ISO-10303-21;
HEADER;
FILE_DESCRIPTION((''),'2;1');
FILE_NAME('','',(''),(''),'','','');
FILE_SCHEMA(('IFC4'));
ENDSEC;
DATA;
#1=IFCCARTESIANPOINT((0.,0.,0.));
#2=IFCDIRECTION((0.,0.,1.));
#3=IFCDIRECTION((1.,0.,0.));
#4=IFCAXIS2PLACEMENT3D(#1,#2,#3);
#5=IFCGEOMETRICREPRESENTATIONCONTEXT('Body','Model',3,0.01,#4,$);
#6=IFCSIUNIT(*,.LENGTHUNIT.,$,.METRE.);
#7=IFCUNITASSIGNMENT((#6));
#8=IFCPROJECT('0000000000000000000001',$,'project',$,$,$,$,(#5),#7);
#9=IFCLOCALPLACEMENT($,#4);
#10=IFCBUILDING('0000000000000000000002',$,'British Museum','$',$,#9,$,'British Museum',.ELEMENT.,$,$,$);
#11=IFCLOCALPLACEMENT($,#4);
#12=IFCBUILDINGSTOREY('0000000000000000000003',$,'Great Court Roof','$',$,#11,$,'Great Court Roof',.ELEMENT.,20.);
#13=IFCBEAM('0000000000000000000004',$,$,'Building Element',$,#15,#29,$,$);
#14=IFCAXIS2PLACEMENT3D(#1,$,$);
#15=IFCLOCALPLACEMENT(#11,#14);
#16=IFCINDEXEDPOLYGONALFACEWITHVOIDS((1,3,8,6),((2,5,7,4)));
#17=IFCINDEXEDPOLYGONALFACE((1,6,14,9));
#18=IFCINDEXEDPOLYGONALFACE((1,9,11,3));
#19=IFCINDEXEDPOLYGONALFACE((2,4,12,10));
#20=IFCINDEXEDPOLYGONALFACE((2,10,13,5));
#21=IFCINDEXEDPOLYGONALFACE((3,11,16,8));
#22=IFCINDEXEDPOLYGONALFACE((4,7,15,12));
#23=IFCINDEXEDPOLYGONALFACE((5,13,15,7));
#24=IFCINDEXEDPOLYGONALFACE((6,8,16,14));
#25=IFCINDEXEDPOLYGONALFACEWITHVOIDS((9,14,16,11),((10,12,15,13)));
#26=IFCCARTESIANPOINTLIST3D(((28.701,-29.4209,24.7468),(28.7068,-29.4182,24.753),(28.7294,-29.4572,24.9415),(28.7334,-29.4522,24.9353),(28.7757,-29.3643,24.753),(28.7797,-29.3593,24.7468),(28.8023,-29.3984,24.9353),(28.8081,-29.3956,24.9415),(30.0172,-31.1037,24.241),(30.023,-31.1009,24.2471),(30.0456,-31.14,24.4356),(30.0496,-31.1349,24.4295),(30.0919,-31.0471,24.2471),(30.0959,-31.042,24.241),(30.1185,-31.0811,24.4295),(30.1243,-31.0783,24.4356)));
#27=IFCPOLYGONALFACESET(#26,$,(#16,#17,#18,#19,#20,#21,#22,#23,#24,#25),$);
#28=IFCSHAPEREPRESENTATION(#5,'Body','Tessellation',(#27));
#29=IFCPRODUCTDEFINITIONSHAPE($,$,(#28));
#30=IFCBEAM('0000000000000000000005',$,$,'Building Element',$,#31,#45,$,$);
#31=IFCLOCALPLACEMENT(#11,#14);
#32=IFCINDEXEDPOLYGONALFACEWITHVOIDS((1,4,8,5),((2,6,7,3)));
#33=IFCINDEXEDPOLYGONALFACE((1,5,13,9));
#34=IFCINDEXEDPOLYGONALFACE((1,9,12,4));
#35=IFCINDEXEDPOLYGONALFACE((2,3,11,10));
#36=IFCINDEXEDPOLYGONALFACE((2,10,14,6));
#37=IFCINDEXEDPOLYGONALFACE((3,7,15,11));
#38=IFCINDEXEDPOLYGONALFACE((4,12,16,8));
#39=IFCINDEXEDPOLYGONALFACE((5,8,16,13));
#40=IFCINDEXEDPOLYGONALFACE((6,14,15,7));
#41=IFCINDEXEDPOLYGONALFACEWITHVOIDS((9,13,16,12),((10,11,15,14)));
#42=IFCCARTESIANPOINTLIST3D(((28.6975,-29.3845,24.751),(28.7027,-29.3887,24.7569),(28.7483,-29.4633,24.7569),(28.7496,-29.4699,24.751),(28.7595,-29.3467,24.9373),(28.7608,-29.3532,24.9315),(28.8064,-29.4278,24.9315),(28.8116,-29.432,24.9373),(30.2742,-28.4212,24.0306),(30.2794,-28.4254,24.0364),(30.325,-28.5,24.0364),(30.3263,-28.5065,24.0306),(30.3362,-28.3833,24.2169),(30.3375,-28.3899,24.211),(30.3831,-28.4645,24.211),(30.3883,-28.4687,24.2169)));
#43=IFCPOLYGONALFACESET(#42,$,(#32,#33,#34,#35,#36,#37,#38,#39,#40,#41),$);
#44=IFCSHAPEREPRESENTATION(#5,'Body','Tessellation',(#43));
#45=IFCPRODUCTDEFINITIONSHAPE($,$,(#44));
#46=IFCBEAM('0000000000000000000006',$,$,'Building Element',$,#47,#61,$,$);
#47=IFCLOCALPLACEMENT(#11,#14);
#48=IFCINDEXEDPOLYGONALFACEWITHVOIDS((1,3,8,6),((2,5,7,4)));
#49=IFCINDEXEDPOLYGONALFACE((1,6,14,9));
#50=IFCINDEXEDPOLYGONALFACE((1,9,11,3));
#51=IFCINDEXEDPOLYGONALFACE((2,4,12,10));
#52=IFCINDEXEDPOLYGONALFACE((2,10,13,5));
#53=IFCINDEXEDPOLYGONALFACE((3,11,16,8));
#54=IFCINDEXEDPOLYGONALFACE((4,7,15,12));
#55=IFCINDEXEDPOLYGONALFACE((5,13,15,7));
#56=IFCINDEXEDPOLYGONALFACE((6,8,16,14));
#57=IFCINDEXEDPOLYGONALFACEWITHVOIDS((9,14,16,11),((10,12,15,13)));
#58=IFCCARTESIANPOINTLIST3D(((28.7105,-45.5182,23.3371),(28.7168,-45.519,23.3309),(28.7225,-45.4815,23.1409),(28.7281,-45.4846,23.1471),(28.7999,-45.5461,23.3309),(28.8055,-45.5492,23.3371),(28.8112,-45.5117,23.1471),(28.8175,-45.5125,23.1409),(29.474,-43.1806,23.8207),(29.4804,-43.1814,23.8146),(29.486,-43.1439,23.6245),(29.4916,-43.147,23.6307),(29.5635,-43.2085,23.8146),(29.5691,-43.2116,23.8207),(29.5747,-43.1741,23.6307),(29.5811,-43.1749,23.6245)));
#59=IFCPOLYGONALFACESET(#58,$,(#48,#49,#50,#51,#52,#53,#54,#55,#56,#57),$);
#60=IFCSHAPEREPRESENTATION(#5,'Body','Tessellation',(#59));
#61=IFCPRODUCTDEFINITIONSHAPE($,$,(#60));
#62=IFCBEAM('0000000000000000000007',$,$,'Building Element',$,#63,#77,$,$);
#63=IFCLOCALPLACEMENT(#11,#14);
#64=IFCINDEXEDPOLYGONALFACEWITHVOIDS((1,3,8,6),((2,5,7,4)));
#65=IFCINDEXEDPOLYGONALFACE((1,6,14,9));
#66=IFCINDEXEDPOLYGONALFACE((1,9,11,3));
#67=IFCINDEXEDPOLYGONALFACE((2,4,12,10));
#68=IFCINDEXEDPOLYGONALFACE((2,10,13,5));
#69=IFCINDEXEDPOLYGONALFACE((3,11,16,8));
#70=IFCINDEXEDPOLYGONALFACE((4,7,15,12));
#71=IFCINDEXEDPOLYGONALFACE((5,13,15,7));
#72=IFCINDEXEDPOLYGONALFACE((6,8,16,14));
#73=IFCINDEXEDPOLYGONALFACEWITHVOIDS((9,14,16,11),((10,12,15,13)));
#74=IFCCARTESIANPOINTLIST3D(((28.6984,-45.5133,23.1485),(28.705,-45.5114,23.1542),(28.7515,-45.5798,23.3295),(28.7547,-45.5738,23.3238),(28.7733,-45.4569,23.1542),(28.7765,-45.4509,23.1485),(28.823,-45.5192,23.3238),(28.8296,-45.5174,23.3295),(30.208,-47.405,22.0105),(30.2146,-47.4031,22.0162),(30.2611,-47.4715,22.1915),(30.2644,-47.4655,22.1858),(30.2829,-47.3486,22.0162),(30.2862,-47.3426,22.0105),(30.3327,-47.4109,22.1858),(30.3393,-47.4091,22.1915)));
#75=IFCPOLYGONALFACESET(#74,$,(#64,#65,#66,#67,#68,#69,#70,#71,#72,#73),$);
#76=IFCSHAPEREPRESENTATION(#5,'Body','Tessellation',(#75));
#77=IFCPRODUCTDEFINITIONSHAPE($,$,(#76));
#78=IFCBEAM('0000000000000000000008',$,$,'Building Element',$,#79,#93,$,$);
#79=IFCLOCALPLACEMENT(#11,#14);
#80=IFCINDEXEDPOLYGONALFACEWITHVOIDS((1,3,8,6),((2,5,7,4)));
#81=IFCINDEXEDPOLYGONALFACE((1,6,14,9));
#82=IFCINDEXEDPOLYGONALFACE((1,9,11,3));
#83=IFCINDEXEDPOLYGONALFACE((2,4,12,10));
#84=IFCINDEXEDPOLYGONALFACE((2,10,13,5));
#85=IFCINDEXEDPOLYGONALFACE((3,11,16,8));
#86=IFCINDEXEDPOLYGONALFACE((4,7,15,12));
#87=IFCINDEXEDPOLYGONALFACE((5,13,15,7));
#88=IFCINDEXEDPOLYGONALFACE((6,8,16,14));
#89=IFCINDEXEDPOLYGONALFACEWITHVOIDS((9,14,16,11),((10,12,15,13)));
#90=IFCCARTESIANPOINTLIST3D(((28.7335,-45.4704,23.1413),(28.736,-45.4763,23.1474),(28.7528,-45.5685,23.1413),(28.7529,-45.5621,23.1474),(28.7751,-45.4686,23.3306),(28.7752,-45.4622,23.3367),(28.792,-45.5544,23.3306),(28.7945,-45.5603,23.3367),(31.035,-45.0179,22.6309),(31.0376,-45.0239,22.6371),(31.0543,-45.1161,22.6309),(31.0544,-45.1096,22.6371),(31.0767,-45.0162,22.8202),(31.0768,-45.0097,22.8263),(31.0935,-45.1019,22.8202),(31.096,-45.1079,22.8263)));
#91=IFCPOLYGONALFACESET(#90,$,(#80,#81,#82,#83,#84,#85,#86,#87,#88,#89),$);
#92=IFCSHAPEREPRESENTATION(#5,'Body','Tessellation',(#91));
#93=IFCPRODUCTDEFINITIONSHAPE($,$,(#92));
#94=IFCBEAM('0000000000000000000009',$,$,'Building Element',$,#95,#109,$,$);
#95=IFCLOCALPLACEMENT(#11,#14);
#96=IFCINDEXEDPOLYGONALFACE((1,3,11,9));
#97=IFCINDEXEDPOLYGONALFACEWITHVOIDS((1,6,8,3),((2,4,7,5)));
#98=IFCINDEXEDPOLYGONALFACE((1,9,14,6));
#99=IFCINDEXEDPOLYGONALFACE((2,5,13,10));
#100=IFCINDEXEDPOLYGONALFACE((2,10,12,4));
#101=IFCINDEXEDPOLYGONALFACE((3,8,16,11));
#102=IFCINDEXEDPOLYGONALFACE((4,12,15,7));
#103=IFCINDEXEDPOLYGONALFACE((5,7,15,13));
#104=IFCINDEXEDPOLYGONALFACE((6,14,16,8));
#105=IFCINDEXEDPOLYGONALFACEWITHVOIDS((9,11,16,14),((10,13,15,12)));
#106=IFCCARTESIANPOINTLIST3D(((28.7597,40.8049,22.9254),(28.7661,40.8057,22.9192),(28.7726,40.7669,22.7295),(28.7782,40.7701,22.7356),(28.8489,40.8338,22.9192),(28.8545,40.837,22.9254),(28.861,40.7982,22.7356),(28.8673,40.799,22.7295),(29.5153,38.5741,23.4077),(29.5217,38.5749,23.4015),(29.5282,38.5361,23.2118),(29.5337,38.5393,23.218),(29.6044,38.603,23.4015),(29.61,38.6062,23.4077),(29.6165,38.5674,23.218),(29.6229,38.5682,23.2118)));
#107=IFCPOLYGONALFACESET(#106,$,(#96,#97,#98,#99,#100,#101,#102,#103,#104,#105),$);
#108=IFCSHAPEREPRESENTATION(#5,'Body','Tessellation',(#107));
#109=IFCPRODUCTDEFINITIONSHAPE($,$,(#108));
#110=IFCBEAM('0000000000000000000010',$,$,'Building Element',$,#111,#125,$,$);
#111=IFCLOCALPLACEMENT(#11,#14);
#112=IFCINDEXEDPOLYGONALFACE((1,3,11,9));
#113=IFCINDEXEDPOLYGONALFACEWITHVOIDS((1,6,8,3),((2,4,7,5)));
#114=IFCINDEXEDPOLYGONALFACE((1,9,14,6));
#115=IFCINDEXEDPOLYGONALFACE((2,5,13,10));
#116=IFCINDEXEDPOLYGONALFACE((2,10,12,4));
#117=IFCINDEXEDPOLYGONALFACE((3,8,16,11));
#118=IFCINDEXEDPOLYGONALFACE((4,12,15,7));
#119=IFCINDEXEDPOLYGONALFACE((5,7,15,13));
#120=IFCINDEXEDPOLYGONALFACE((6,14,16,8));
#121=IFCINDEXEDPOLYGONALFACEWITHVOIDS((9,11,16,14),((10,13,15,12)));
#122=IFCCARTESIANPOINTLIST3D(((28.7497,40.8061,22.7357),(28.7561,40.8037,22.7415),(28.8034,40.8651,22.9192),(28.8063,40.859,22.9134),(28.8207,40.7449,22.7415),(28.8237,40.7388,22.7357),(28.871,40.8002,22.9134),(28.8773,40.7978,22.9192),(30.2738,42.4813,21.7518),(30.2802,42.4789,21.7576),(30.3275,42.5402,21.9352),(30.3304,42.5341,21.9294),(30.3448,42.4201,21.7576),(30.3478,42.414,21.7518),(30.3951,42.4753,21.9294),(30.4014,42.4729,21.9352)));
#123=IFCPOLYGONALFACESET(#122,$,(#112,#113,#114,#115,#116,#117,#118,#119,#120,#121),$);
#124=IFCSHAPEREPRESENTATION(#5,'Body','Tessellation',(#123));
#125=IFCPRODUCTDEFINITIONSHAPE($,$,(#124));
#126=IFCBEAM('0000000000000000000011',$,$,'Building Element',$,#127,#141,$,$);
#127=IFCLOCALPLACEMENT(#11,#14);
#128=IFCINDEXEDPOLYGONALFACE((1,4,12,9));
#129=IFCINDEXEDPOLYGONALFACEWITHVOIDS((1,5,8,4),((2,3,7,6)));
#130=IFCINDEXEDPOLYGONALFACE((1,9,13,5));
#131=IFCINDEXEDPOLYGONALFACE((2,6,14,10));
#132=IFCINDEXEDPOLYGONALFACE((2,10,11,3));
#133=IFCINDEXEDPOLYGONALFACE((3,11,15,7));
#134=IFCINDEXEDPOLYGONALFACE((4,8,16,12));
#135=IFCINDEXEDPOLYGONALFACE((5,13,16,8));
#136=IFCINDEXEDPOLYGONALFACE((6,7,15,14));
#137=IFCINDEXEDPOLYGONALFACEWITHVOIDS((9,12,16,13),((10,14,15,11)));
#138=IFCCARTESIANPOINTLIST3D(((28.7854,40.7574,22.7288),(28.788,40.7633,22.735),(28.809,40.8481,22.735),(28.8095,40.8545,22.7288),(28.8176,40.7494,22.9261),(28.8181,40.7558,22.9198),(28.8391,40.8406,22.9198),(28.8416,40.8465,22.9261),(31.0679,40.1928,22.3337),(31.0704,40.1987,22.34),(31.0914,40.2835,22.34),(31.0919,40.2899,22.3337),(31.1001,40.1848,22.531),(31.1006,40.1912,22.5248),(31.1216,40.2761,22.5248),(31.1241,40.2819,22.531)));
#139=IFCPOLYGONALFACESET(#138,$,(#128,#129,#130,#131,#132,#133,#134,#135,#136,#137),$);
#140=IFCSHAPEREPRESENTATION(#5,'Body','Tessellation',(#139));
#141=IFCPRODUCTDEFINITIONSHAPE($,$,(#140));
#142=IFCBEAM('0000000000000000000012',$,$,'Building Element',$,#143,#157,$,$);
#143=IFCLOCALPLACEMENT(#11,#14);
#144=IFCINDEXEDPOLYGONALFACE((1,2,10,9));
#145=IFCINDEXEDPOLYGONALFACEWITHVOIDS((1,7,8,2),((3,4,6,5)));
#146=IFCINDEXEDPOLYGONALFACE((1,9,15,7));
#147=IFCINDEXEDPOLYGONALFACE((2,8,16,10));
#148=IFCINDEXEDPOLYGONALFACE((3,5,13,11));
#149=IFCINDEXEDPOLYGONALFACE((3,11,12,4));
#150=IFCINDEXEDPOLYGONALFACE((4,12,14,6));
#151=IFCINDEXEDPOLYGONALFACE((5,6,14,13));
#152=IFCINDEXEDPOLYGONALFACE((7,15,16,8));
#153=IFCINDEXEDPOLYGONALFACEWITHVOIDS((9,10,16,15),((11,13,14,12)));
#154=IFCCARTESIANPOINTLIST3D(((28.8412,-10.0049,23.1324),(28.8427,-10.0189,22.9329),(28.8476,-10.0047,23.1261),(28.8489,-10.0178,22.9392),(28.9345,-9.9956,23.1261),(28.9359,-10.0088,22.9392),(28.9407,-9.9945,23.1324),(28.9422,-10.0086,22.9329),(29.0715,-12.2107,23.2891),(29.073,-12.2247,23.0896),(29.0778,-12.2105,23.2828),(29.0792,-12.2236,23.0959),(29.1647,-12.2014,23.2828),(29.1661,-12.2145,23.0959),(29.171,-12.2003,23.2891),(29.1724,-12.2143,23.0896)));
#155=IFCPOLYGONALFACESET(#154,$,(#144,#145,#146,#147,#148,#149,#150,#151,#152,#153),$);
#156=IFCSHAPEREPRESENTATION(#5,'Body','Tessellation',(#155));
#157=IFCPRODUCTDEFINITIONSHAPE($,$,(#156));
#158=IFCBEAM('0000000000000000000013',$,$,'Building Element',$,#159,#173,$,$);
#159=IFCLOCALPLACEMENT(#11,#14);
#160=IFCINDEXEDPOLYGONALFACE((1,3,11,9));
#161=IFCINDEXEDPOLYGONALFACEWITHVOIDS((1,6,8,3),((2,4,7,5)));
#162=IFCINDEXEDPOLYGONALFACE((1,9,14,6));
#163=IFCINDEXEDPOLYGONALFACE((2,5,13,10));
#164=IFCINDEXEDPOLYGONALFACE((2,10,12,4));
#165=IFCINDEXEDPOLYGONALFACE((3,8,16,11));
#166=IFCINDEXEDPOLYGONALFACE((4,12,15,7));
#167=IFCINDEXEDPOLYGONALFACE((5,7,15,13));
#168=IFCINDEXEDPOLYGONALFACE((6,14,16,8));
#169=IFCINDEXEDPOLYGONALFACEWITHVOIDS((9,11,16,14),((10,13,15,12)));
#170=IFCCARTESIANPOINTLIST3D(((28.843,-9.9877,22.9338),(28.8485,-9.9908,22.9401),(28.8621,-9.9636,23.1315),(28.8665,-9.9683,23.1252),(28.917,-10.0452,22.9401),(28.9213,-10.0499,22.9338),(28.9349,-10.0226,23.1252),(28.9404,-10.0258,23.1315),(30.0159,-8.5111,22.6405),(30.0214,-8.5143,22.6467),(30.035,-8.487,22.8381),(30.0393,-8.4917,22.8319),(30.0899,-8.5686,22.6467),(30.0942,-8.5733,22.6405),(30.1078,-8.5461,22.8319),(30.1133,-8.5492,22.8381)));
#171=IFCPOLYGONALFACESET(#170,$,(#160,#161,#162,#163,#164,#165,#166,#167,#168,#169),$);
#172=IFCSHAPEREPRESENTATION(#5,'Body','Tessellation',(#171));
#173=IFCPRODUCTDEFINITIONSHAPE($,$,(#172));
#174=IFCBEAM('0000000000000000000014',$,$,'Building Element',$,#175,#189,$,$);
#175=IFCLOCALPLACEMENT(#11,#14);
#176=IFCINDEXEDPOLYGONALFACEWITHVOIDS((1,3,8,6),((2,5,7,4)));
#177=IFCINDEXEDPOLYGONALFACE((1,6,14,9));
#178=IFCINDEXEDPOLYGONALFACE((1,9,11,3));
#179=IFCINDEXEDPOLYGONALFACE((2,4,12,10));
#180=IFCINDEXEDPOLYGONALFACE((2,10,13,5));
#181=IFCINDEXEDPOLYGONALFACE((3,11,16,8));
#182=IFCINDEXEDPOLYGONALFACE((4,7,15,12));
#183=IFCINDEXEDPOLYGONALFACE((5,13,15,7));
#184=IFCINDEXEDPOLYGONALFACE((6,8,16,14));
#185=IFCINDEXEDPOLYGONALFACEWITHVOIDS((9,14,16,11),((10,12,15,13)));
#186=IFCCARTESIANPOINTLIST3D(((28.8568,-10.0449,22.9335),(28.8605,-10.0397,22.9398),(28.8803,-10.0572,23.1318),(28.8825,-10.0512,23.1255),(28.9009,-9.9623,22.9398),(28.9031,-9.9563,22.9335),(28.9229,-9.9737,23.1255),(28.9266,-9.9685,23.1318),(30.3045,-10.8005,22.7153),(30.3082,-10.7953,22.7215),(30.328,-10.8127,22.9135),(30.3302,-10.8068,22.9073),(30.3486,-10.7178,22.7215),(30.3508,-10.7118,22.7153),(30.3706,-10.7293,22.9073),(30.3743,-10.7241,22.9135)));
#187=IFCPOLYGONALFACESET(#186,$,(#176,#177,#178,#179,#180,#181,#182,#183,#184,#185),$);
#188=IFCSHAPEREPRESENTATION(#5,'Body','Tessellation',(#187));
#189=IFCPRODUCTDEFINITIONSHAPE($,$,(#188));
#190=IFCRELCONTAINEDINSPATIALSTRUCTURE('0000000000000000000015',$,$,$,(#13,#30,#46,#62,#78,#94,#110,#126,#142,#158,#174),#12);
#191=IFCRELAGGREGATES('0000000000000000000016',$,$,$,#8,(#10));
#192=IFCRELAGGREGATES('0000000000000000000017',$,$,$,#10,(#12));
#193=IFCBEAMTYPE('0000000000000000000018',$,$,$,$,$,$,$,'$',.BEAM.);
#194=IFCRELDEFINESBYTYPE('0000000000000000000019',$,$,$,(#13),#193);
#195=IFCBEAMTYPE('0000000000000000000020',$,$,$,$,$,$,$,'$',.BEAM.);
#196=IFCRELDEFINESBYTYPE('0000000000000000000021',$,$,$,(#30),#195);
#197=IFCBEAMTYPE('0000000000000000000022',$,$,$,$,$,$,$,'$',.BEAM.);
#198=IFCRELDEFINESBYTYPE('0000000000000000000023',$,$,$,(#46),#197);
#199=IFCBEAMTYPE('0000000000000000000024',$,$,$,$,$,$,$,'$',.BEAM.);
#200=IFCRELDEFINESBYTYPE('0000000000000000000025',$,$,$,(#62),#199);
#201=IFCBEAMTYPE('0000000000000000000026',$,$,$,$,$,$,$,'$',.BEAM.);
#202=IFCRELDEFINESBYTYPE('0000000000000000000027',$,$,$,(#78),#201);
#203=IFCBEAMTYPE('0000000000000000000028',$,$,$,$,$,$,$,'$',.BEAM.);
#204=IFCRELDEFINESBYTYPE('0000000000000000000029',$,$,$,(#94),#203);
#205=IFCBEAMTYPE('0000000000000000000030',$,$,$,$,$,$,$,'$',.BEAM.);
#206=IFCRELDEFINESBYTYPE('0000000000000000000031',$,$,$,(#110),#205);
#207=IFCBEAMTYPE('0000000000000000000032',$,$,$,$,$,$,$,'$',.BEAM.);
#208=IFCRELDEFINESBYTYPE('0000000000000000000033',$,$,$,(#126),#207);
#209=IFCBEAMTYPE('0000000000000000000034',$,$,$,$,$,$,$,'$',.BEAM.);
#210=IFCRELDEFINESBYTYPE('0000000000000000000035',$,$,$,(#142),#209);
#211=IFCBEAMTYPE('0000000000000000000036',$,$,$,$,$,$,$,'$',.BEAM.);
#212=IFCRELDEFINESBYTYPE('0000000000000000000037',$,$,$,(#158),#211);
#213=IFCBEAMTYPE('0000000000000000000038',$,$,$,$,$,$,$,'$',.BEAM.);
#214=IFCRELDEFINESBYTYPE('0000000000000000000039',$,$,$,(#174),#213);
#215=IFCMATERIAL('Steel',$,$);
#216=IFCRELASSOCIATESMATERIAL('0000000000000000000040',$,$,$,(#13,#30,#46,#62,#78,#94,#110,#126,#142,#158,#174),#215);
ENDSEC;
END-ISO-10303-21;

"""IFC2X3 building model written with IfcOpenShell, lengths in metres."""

from ifc_helpers import new_model, si_unit, frame, origin_with_axes, origin_2d, place, context, project, spatial, hollow_rectangle, extrude, material, type_object, element, save


model = new_model("IFC2X3")

# Units and contexts
model_context = context("Model", 3, precision=0.01, world=origin_with_axes(), identifier="Body")
ifc_project = project(units=[si_unit("LENGTHUNIT", "METRE")], contexts=[model_context])

# Building, storey
building_placement = place(None, origin_with_axes())
building = spatial("IfcBuilding", under=ifc_project, at=building_placement, Name="British Museum", Description="$", LongName="British Museum", CompositionType="ELEMENT")
storey_placement = place(None, origin_with_axes())
storey = spatial("IfcBuildingStorey", under=building, at=storey_placement, Name="Great Court Roof", Description="$", LongName="Great Court Roof", CompositionType="ELEMENT", Elevation=20.0)

# Beams
ifc_material = material(Name="Steel")
beam_type_1 = type_object("IfcBeamType", ElementType="$", PredefinedType="BEAM")
beam_1_placement = place(None, origin_with_axes())
element("IfcBeam", 1, at=beam_1_placement, inside=storey, type_object=beam_type_1, material=ifc_material, Description="Building Element", context=model_context, shape_type="SweptSolid", body=[
    extrude(hollow_rectangle(XDim=0.1, YDim=0.2, WallThickness=0.0063, InnerFilletRadius=-0.0063, OuterFilletRadius=0.0, at=origin_2d()), frame((28.7546, -29.4083, 24.8442), z_axis=(0.599519, -0.766476, -0.230416), x_axis=(0.787671, 0.616096, 0.0)), (0.0, 0.0, 1.0), 2.1954),
])
beam_type_2 = type_object("IfcBeamType", ElementType="$", PredefinedType="BEAM")
beam_2_placement = place(None, origin_with_axes())
element("IfcBeam", 2, at=beam_2_placement, inside=storey, type_object=beam_type_2, material=ifc_material, Description="Building Element", context=model_context, shape_type="SweptSolid", body=[
    extrude(hollow_rectangle(XDim=0.1, YDim=0.2, WallThickness=0.0063, InnerFilletRadius=-0.0063, OuterFilletRadius=0.0, at=origin_2d()), frame((28.7546, -29.4083, 24.8442), z_axis=(0.795036, 0.485752, -0.363267), x_axis=(-0.52137, 0.853331, 0.0)), (0.0, 0.0, 1.0), 1.9832),
])
beam_type_3 = type_object("IfcBeamType", ElementType="$", PredefinedType="BEAM")
beam_3_placement = place(None, origin_with_axes())
element("IfcBeam", 3, at=beam_3_placement, inside=storey, type_object=beam_type_3, material=ifc_material, Description="Building Element", context=model_context, shape_type="SweptSolid", body=[
    extrude(hollow_rectangle(XDim=0.1, YDim=0.2, WallThickness=0.0063, InnerFilletRadius=-0.0063, OuterFilletRadius=0.0, at=origin_2d()), frame((28.764, -45.5153, 23.239), z_axis=(0.304657, 0.93271, 0.19297), x_axis=(-0.950576, 0.310492, 0.0)), (0.0, 0.0, 1.0), 2.5063),
])
beam_type_4 = type_object("IfcBeamType", ElementType="$", PredefinedType="BEAM")
beam_4_placement = place(None, origin_with_axes())
element("IfcBeam", 4, at=beam_4_placement, inside=storey, type_object=beam_type_4, material=ifc_material, Description="Building Element", context=model_context, shape_type="SweptSolid", body=[
    extrude(hollow_rectangle(XDim=0.1, YDim=0.2, WallThickness=0.0063, InnerFilletRadius=-0.0063, OuterFilletRadius=0.0, at=origin_2d()), frame((28.764, -45.5153, 23.239), z_axis=(0.56447, -0.707328, -0.425513), x_axis=(0.781619, 0.623756, 0.0)), (0.0, 0.0, 1.0), 2.6744),
])
beam_type_5 = type_object("IfcBeamType", ElementType="$", PredefinedType="BEAM")
beam_5_placement = place(None, origin_with_axes())
element("IfcBeam", 5, at=beam_5_placement, inside=storey, type_object=beam_type_5, material=ifc_material, Description="Building Element", context=model_context, shape_type="SweptSolid", body=[
    extrude(hollow_rectangle(XDim=0.1, YDim=0.2, WallThickness=0.0063, InnerFilletRadius=-0.0063, OuterFilletRadius=0.0, at=origin_2d()), frame((28.764, -45.5153, 23.239), z_axis=(0.958786, 0.188478, -0.212616), x_axis=(-0.192888, 0.981221, 0.0)), (0.0, 0.0, 1.0), 2.4005),
])
beam_type_6 = type_object("IfcBeamType", ElementType="$", PredefinedType="BEAM")
beam_6_placement = place(None, origin_with_axes())
element("IfcBeam", 6, at=beam_6_placement, inside=storey, type_object=beam_type_6, material=ifc_material, Description="Building Element", context=model_context, shape_type="SweptSolid", body=[
    extrude(hollow_rectangle(XDim=0.1, YDim=0.2, WallThickness=0.0063, InnerFilletRadius=-0.0063, OuterFilletRadius=0.0, at=origin_2d()), frame((28.8135, 40.8019, 22.8274), z_axis=(0.314267, -0.927895, 0.200615), x_axis=(0.947151, 0.320788, 0.0)), (0.0, 0.0, 1.0), 2.4041),
])
beam_type_7 = type_object("IfcBeamType", ElementType="$", PredefinedType="BEAM")
beam_7_placement = place(None, origin_with_axes())
element("IfcBeam", 7, at=beam_7_placement, inside=storey, type_object=beam_type_7, material=ifc_material, Description="Building Element", context=model_context, shape_type="SweptSolid", body=[
    extrude(hollow_rectangle(XDim=0.1, YDim=0.2, WallThickness=0.0063, InnerFilletRadius=-0.0063, OuterFilletRadius=0.0, at=origin_2d()), frame((28.8135, 40.8019, 22.8274), z_axis=(0.617237, 0.678407, -0.398475), x_axis=(-0.739667, 0.672973, 0.0)), (0.0, 0.0, 1.0), 2.4692),
])
beam_type_8 = type_object("IfcBeamType", ElementType="$", PredefinedType="BEAM")
beam_8_placement = place(None, origin_with_axes())
element("IfcBeam", 8, at=beam_8_placement, inside=storey, type_object=beam_type_8, material=ifc_material, Description="Building Element", context=model_context, shape_type="SweptSolid", body=[
    extrude(hollow_rectangle(XDim=0.1, YDim=0.2, WallThickness=0.0063, InnerFilletRadius=-0.0063, OuterFilletRadius=0.0, at=origin_2d()), frame((28.8135, 40.8019, 22.8274), z_axis=(0.957322, -0.236803, -0.165707), x_axis=(0.240123, 0.970742, 0.0)), (0.0, 0.0, 1.0), 2.3842),
])
beam_type_9 = type_object("IfcBeamType", ElementType="$", PredefinedType="BEAM")
beam_9_placement = place(None, origin_with_axes())
element("IfcBeam", 9, at=beam_9_placement, inside=storey, type_object=beam_type_9, material=ifc_material, Description="Building Element", context=model_context, shape_type="SweptSolid", body=[
    extrude(hollow_rectangle(XDim=0.1, YDim=0.2, WallThickness=0.0063, InnerFilletRadius=-0.0063, OuterFilletRadius=0.0, at=origin_2d()), frame((28.8917, -10.0067, 23.0326), z_axis=(0.103561, -0.992122, 0.070488), x_axis=(0.994596, 0.10382, 0.0)), (0.0, 0.0, 1.0), 2.2233),
])
beam_type_10 = type_object("IfcBeamType", ElementType="$", PredefinedType="BEAM")
beam_10_placement = place(None, origin_with_axes())
element("IfcBeam", 10, at=beam_10_placement, inside=storey, type_object=beam_type_10, material=ifc_material, Description="Building Element", context=model_context, shape_type="SweptSolid", body=[
    extrude(hollow_rectangle(XDim=0.1, YDim=0.2, WallThickness=0.0063, InnerFilletRadius=-0.0063, OuterFilletRadius=0.0, at=origin_2d()), frame((28.8917, -10.0067, 23.0326), z_axis=(0.614594, 0.773722, -0.153716), x_axis=(-0.783028, 0.621986, 0.0)), (0.0, 0.0, 1.0), 1.9084),
])
beam_type_11 = type_object("IfcBeamType", ElementType="$", PredefinedType="BEAM")
beam_11_placement = place(None, origin_with_axes())
element("IfcBeam", 11, at=beam_11_placement, inside=storey, type_object=beam_type_11, material=ifc_material, Description="Building Element", context=model_context, shape_type="SweptSolid", body=[
    extrude(hollow_rectangle(XDim=0.1, YDim=0.2, WallThickness=0.0063, InnerFilletRadius=-0.0063, OuterFilletRadius=0.0, at=origin_2d()), frame((28.8917, -10.0067, 23.0326), z_axis=(0.878719, -0.458589, -0.132472), x_axis=(0.462666, 0.886532, 0.0)), (0.0, 0.0, 1.0), 1.6475),
])

save(model, "model.ifc")
